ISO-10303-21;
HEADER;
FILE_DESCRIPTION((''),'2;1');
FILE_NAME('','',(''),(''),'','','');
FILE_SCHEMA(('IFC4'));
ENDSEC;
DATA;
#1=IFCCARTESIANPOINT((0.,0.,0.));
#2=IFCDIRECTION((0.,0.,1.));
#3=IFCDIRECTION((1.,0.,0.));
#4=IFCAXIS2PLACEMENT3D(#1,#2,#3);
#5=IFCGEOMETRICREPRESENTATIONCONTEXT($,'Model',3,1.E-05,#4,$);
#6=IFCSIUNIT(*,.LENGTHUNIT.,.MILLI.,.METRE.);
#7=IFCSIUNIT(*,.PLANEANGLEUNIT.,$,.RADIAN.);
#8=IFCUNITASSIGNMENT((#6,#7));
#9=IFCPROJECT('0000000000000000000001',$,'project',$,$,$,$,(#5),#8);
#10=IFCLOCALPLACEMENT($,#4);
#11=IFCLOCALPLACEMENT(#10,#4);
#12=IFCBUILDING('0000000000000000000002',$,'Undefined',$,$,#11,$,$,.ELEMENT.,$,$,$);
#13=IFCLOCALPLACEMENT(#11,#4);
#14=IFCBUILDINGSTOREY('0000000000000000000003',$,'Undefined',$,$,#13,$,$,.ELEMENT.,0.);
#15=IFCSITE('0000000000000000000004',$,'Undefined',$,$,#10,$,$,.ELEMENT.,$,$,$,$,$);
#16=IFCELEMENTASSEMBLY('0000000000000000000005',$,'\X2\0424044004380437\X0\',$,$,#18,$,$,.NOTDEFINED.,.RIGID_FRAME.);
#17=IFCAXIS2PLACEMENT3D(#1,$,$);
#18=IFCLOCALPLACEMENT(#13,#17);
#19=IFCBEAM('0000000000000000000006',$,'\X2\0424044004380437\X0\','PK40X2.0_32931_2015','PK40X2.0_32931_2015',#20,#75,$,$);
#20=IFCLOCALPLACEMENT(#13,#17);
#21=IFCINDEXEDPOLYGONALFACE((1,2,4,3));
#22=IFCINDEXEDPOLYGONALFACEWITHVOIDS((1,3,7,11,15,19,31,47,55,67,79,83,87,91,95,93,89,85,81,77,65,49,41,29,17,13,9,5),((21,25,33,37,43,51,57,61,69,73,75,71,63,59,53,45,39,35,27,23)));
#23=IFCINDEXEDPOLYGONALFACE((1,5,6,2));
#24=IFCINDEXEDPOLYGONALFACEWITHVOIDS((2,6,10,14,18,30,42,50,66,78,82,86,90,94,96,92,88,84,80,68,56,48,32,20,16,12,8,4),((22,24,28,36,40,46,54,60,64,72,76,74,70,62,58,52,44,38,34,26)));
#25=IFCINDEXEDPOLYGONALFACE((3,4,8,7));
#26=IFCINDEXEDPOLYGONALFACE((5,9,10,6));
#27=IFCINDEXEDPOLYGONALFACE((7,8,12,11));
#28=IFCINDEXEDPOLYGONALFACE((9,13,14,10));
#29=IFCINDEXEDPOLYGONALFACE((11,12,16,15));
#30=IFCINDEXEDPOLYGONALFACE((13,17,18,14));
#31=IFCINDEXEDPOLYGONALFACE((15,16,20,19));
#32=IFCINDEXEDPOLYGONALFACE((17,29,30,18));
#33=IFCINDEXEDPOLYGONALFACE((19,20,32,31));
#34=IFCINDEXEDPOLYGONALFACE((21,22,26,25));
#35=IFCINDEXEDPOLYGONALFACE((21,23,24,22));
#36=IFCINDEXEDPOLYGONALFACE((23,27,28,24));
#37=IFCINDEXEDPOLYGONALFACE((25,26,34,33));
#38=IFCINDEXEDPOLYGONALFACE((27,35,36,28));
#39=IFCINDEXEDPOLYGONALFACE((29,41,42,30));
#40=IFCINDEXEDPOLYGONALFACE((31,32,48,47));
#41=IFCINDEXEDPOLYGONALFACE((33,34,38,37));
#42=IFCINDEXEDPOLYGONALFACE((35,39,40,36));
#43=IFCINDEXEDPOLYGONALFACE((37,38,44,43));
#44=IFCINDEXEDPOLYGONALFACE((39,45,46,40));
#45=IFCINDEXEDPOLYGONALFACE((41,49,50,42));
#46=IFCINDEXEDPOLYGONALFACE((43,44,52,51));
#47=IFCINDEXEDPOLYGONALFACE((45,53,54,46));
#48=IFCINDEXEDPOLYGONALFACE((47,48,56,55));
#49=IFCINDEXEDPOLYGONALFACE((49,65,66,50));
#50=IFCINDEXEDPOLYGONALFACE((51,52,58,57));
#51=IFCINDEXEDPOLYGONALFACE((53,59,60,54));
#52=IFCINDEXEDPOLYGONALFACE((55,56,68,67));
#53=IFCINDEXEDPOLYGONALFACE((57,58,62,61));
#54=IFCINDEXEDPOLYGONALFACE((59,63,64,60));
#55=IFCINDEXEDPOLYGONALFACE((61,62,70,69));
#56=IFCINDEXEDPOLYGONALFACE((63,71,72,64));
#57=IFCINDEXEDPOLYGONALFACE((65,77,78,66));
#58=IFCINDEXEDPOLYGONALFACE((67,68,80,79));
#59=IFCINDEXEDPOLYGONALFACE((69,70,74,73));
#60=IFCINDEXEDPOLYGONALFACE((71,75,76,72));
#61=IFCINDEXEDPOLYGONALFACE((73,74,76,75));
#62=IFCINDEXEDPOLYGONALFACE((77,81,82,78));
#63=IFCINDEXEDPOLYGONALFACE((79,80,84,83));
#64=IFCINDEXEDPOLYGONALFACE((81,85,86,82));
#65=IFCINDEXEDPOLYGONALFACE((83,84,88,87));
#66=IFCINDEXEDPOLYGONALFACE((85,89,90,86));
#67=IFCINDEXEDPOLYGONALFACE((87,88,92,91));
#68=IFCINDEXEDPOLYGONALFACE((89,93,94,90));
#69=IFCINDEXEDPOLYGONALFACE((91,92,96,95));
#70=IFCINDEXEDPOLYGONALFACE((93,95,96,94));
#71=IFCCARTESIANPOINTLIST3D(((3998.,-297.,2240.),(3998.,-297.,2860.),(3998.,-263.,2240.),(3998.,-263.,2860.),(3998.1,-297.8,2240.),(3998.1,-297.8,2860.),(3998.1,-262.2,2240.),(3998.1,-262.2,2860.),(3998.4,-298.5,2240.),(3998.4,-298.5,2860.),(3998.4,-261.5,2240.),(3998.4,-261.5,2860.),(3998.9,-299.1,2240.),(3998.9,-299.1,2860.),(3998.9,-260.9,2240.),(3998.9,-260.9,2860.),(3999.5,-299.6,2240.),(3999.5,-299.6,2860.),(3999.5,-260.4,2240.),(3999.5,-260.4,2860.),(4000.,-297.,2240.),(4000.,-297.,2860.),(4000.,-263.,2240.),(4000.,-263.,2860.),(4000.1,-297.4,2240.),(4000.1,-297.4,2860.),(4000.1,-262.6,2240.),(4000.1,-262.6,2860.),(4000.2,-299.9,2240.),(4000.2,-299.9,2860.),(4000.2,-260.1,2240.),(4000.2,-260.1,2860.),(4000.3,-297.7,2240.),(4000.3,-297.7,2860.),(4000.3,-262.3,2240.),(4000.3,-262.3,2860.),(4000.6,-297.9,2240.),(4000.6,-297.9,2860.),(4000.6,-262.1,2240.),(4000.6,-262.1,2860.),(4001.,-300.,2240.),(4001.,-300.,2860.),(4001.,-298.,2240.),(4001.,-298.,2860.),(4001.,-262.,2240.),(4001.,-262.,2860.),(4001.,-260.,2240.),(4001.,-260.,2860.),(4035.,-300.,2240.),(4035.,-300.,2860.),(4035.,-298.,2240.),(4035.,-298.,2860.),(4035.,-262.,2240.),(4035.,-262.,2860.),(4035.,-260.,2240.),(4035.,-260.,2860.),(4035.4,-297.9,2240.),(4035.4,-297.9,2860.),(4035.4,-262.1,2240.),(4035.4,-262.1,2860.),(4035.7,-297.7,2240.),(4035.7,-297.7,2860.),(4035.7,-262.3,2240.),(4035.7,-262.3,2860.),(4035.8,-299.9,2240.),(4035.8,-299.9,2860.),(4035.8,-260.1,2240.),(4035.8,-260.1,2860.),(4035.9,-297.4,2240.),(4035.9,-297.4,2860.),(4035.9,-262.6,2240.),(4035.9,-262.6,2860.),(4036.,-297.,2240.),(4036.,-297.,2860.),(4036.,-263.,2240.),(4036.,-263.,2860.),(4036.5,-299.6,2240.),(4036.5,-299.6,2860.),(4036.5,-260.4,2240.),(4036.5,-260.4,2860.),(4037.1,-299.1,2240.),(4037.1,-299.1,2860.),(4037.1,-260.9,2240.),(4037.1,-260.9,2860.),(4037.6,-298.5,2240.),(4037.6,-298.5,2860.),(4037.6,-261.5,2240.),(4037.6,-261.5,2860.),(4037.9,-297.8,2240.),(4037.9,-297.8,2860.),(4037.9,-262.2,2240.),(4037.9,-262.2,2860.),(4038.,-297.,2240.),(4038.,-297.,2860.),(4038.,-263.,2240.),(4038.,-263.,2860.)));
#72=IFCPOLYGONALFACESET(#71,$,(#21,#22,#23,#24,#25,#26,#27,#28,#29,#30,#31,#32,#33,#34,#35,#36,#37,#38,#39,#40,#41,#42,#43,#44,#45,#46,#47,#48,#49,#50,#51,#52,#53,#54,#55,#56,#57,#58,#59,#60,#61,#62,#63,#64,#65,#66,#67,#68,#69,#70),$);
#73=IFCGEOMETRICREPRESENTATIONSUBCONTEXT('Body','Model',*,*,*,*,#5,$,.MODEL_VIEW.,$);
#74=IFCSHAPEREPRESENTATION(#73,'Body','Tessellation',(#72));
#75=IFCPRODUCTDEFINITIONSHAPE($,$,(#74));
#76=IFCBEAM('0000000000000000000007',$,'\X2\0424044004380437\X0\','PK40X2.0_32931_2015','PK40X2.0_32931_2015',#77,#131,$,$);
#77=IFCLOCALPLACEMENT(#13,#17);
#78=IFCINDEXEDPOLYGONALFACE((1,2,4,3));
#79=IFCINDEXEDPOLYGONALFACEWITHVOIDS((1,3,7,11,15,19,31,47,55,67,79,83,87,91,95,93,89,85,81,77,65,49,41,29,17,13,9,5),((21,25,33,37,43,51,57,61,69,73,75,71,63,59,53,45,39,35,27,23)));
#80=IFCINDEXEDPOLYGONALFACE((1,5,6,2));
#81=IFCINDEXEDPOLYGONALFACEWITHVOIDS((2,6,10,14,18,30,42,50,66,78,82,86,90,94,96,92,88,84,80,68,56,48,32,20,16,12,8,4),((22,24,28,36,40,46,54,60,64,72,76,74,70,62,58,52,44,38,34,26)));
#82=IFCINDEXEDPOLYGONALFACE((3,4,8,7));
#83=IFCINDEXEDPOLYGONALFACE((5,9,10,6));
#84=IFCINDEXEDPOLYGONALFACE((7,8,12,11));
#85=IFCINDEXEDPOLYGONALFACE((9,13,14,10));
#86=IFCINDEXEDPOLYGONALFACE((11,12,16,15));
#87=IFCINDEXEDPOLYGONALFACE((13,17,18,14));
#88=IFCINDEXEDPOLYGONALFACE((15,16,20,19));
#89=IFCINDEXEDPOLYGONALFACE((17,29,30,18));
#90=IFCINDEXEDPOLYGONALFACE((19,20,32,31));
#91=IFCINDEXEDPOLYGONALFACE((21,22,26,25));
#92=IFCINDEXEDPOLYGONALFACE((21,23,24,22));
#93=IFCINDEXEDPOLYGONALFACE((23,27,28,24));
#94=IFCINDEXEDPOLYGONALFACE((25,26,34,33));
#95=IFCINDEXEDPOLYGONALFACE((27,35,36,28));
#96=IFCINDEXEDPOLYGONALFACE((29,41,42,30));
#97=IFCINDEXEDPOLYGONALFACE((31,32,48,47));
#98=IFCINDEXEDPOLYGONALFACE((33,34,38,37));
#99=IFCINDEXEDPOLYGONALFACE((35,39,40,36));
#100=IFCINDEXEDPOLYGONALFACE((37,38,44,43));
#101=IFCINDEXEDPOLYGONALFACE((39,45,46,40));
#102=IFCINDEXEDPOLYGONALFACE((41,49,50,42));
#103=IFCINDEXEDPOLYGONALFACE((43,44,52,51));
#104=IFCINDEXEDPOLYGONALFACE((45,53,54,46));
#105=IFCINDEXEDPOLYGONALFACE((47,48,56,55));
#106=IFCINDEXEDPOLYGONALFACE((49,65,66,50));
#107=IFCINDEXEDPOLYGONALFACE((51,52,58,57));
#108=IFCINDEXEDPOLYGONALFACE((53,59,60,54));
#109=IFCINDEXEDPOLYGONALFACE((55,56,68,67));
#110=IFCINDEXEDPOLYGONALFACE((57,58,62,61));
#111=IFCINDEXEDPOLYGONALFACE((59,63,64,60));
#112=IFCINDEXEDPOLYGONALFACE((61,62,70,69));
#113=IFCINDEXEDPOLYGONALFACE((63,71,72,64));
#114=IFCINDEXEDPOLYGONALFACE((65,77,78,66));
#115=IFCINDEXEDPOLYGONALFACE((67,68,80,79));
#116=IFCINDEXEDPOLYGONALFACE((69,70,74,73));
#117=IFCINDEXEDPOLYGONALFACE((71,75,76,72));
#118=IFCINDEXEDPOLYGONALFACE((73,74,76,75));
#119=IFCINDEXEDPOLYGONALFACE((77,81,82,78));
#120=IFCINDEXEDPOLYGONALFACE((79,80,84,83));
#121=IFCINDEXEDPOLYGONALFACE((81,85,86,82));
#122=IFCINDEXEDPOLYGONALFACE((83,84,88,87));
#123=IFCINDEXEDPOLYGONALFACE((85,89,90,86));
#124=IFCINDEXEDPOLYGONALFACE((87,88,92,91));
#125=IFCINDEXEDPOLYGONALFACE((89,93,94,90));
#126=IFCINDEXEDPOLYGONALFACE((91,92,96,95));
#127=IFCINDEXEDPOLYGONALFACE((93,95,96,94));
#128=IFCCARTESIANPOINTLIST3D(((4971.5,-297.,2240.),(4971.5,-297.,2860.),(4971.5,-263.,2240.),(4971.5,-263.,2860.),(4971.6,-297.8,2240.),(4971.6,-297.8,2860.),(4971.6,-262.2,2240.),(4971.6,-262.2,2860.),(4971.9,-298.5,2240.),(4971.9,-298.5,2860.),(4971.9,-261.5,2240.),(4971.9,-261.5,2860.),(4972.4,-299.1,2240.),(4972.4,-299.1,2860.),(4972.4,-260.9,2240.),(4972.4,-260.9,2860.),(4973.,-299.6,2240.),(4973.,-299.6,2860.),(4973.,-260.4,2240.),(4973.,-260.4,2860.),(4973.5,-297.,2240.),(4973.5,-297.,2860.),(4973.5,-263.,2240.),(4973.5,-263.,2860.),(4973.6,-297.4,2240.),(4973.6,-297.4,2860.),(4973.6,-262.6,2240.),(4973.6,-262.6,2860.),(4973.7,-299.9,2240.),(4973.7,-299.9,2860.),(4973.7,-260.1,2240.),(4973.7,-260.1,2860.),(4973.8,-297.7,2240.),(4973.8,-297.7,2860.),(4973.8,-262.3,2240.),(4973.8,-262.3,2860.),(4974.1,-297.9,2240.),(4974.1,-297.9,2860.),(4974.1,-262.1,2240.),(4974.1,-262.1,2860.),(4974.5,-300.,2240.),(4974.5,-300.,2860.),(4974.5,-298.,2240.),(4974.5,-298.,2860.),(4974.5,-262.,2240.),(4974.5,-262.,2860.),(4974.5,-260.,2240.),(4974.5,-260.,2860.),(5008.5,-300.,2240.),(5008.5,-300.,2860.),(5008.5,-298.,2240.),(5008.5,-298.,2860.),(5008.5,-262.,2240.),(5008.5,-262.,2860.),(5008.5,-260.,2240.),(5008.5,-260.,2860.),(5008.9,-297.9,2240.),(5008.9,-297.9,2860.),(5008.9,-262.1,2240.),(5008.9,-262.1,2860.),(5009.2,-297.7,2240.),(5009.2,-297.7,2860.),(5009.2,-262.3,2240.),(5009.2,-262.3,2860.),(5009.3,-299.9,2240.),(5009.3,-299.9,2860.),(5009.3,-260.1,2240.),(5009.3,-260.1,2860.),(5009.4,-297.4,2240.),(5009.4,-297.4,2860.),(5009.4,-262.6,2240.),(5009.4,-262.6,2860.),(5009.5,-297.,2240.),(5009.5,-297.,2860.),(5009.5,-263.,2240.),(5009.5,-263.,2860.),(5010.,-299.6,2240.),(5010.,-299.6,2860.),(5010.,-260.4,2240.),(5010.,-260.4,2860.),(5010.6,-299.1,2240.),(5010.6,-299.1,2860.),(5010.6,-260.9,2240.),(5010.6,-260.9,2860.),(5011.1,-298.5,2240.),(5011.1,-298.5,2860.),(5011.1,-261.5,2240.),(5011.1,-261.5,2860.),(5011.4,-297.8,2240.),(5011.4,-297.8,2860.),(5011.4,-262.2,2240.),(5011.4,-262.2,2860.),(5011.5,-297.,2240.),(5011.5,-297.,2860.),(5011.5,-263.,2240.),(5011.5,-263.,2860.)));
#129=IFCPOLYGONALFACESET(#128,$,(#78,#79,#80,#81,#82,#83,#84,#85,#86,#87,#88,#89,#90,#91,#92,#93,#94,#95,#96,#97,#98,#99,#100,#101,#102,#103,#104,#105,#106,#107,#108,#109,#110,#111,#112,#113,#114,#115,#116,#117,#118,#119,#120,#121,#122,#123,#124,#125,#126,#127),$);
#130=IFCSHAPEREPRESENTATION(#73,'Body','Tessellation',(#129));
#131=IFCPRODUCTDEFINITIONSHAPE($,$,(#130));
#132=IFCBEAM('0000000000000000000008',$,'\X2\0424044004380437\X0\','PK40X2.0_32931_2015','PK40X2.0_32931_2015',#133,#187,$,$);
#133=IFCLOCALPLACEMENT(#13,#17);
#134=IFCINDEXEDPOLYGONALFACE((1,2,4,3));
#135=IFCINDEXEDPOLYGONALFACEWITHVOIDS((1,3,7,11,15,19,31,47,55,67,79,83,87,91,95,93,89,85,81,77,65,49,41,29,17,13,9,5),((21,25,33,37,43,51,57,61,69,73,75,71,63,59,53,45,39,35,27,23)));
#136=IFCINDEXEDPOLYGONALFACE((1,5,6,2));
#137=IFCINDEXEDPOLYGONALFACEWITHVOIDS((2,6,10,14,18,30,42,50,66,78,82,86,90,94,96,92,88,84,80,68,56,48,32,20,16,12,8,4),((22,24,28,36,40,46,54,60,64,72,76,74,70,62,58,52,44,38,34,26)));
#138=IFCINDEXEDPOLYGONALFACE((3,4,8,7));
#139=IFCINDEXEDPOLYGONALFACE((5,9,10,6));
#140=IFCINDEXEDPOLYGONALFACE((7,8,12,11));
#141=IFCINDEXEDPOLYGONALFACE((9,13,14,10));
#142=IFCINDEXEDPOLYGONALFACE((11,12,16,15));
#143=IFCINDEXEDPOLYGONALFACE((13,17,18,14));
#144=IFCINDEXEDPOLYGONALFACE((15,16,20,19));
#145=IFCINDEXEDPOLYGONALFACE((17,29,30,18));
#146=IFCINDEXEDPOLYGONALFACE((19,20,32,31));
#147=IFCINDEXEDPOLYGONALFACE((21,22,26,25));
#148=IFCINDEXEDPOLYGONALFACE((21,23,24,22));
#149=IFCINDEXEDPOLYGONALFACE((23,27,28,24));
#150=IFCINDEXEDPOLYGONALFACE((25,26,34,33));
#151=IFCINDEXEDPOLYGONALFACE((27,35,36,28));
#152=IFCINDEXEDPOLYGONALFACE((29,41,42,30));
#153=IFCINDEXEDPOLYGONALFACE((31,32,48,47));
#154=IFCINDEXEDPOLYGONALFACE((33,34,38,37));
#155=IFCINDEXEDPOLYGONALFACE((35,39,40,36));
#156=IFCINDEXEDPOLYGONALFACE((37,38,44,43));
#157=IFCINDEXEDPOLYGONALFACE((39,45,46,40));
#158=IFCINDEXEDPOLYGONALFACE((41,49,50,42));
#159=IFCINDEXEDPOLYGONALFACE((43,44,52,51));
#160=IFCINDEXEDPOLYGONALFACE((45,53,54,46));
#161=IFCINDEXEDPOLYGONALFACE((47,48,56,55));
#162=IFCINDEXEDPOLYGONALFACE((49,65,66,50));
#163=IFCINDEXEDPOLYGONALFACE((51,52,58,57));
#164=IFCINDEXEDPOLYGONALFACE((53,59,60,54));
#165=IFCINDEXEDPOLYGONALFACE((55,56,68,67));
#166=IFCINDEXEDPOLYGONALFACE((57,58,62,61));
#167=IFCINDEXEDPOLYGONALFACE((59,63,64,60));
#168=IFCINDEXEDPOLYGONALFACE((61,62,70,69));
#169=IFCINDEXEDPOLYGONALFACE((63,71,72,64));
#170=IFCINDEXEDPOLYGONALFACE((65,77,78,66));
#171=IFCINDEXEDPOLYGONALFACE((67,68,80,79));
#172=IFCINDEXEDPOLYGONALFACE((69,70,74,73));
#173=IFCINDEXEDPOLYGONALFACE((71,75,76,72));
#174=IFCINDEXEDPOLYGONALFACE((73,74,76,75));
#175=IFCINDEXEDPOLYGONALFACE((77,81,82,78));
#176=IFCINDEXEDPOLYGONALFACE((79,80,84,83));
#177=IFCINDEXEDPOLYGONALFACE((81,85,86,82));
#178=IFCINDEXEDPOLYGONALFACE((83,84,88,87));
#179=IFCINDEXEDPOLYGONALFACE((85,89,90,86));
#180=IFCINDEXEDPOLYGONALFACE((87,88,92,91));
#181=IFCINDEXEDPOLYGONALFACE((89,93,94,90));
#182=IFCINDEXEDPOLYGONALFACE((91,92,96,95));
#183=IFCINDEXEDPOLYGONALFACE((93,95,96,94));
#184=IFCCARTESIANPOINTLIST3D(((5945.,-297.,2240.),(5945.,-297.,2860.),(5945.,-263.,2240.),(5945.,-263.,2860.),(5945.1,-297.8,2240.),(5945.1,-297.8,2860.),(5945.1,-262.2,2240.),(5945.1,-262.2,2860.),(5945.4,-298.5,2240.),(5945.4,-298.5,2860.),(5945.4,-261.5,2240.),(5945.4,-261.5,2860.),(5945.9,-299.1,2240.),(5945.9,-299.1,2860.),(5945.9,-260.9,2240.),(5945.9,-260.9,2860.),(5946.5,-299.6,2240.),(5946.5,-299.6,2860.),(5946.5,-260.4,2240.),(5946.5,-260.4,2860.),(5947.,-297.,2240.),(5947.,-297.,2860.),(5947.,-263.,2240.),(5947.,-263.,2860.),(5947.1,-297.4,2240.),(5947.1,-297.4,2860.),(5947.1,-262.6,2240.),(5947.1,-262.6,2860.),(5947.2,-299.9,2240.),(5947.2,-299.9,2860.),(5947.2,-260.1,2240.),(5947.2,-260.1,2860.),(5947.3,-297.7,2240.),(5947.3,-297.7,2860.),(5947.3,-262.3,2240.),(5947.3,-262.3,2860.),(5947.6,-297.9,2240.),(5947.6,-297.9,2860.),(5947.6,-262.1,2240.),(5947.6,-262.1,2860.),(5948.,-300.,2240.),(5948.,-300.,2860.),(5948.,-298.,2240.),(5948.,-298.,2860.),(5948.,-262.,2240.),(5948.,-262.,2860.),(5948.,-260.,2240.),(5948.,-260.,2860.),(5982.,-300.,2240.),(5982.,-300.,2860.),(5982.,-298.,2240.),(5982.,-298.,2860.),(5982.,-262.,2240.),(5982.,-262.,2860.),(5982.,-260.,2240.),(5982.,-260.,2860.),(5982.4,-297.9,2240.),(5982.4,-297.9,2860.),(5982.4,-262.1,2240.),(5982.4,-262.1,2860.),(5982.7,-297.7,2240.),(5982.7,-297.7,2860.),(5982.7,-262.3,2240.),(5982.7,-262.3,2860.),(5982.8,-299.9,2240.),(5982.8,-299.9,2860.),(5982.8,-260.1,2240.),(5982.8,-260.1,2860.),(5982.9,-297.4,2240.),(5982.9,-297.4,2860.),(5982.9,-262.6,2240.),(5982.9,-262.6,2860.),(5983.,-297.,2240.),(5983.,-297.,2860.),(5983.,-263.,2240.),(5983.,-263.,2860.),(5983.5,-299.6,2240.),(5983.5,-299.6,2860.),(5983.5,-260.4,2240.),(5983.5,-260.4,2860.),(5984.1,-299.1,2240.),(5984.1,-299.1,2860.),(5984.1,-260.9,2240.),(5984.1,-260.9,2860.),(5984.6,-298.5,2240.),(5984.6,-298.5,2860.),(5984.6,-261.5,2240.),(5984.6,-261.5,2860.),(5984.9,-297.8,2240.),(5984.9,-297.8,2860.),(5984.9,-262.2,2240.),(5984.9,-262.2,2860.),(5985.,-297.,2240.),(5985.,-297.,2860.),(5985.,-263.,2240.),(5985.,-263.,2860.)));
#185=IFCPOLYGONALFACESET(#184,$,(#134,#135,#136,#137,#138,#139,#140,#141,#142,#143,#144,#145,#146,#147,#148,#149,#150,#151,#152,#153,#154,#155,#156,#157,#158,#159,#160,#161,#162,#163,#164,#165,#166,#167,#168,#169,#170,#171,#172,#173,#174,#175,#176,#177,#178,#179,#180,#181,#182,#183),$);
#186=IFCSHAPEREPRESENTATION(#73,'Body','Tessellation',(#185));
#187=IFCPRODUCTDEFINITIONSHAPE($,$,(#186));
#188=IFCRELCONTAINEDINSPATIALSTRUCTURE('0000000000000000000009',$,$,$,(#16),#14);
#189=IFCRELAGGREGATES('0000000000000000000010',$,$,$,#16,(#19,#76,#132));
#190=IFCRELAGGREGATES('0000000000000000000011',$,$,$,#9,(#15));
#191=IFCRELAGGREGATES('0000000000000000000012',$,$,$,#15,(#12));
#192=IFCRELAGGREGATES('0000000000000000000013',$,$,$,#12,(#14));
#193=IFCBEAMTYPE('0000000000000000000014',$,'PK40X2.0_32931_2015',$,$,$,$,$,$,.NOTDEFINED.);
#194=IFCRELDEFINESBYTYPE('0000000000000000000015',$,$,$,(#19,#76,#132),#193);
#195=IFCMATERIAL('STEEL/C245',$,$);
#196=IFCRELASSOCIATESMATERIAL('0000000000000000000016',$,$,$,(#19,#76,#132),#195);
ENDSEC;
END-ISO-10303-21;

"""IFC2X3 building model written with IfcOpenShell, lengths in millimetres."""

from ifc_helpers import new_model, si_unit, frame, origin_with_axes, origin_2d_with_axis, place, context, subcontext, project, spatial, hollow_rectangle, extrude, material, type_object, element, aggregate, save


model = new_model("IFC2X3")

# Units and contexts
model_context = context("Model", 3, precision=1e-05, world=origin_with_axes())
body_context = subcontext(model_context, "Body", "Model", "MODEL_VIEW")
ifc_project = project(units=[si_unit("LENGTHUNIT", "METRE", prefix="MILLI"), si_unit("PLANEANGLEUNIT", "RADIAN")], contexts=[model_context])

# Site, building, storey
site_placement = place(None, origin_with_axes())
site = spatial("IfcSite", under=ifc_project, at=site_placement, Name="Undefined", CompositionType="ELEMENT")
building_placement = place(site_placement, origin_with_axes())
building = spatial("IfcBuilding", under=site, at=building_placement, Name="Undefined", CompositionType="ELEMENT")
storey_placement = place(building_placement, origin_with_axes())
storey = spatial("IfcBuildingStorey", under=building, at=storey_placement, Name="Undefined", CompositionType="ELEMENT", Elevation=0.0)

# Shared definitions
ifc_material_1 = material(Name="STEEL/C245")

# Element assembly, beams
assembly_1_placement = place(storey_placement, origin_with_axes())
assembly_1 = element("IfcElementAssembly", 1, at=assembly_1_placement, inside=storey, Name="Фриз", AssemblyPlace="NOTDEFINED", PredefinedType="RIGID_FRAME")
beam_type_1 = type_object("IfcBeamType", Name="PK40X2.0_32931_2015", PredefinedType="NOTDEFINED")
beam_1_placement = place(assembly_1_placement, frame((4018.0, -280.0, 2860.0), z_axis=(1.0, 0.0, 0.0), x_axis=(0.0, 0.0, -1.0)))
beam_1 = element("IfcBeam", 2, at=beam_1_placement, type_object=beam_type_1, material=ifc_material_1, Name="Фриз", Description="PK40X2.0_32931_2015", ObjectType="PK40X2.0_32931_2015", context=body_context, shape_type="SweptSolid", body=[
    extrude(hollow_rectangle(XDim=40.0, YDim=40.0, WallThickness=2.0, InnerFilletRadius=1.0, OuterFilletRadius=3.0, at=origin_2d_with_axis()), frame((620.0, 0.0, 0.0), z_axis=(-1.0, 0.0, 0.0), x_axis=(0.0, -1.0, 0.0)), (0.0, 0.0, 1.0), 620.0),
])
beam_2_placement = place(assembly_1_placement, frame((4991.5, -280.0, 2860.0), z_axis=(1.0, 0.0, 0.0), x_axis=(0.0, 0.0, -1.0)))
beam_2 = element("IfcBeam", 3, at=beam_2_placement, type_object=beam_type_1, material=ifc_material_1, Name="Фриз", Description="PK40X2.0_32931_2015", ObjectType="PK40X2.0_32931_2015", context=body_context, shape_type="SweptSolid", body=[
    extrude(hollow_rectangle(XDim=40.0, YDim=40.0, WallThickness=2.0, InnerFilletRadius=1.0, OuterFilletRadius=3.0, at=origin_2d_with_axis()), frame((620.0, 0.0, 0.0), z_axis=(-1.0, 0.0, 0.0), x_axis=(0.0, -1.0, 0.0)), (0.0, 0.0, 1.0), 620.0),
])
beam_3_placement = place(assembly_1_placement, frame((5965.0, -280.0, 2860.0), z_axis=(1.0, 0.0, 0.0), x_axis=(0.0, 0.0, -1.0)))
beam_3 = element("IfcBeam", 4, at=beam_3_placement, type_object=beam_type_1, material=ifc_material_1, Name="Фриз", Description="PK40X2.0_32931_2015", ObjectType="PK40X2.0_32931_2015", context=body_context, shape_type="SweptSolid", body=[
    extrude(hollow_rectangle(XDim=40.0, YDim=40.0, WallThickness=2.0, InnerFilletRadius=1.0, OuterFilletRadius=3.0, at=origin_2d_with_axis()), frame((620.0, 0.0, 0.0), z_axis=(-1.0, 0.0, 0.0), x_axis=(0.0, -1.0, 0.0)), (0.0, 0.0, 1.0), 620.0),
])
aggregate(assembly_1, [beam_1, beam_2, beam_3])

save(model, "model.ifc")
